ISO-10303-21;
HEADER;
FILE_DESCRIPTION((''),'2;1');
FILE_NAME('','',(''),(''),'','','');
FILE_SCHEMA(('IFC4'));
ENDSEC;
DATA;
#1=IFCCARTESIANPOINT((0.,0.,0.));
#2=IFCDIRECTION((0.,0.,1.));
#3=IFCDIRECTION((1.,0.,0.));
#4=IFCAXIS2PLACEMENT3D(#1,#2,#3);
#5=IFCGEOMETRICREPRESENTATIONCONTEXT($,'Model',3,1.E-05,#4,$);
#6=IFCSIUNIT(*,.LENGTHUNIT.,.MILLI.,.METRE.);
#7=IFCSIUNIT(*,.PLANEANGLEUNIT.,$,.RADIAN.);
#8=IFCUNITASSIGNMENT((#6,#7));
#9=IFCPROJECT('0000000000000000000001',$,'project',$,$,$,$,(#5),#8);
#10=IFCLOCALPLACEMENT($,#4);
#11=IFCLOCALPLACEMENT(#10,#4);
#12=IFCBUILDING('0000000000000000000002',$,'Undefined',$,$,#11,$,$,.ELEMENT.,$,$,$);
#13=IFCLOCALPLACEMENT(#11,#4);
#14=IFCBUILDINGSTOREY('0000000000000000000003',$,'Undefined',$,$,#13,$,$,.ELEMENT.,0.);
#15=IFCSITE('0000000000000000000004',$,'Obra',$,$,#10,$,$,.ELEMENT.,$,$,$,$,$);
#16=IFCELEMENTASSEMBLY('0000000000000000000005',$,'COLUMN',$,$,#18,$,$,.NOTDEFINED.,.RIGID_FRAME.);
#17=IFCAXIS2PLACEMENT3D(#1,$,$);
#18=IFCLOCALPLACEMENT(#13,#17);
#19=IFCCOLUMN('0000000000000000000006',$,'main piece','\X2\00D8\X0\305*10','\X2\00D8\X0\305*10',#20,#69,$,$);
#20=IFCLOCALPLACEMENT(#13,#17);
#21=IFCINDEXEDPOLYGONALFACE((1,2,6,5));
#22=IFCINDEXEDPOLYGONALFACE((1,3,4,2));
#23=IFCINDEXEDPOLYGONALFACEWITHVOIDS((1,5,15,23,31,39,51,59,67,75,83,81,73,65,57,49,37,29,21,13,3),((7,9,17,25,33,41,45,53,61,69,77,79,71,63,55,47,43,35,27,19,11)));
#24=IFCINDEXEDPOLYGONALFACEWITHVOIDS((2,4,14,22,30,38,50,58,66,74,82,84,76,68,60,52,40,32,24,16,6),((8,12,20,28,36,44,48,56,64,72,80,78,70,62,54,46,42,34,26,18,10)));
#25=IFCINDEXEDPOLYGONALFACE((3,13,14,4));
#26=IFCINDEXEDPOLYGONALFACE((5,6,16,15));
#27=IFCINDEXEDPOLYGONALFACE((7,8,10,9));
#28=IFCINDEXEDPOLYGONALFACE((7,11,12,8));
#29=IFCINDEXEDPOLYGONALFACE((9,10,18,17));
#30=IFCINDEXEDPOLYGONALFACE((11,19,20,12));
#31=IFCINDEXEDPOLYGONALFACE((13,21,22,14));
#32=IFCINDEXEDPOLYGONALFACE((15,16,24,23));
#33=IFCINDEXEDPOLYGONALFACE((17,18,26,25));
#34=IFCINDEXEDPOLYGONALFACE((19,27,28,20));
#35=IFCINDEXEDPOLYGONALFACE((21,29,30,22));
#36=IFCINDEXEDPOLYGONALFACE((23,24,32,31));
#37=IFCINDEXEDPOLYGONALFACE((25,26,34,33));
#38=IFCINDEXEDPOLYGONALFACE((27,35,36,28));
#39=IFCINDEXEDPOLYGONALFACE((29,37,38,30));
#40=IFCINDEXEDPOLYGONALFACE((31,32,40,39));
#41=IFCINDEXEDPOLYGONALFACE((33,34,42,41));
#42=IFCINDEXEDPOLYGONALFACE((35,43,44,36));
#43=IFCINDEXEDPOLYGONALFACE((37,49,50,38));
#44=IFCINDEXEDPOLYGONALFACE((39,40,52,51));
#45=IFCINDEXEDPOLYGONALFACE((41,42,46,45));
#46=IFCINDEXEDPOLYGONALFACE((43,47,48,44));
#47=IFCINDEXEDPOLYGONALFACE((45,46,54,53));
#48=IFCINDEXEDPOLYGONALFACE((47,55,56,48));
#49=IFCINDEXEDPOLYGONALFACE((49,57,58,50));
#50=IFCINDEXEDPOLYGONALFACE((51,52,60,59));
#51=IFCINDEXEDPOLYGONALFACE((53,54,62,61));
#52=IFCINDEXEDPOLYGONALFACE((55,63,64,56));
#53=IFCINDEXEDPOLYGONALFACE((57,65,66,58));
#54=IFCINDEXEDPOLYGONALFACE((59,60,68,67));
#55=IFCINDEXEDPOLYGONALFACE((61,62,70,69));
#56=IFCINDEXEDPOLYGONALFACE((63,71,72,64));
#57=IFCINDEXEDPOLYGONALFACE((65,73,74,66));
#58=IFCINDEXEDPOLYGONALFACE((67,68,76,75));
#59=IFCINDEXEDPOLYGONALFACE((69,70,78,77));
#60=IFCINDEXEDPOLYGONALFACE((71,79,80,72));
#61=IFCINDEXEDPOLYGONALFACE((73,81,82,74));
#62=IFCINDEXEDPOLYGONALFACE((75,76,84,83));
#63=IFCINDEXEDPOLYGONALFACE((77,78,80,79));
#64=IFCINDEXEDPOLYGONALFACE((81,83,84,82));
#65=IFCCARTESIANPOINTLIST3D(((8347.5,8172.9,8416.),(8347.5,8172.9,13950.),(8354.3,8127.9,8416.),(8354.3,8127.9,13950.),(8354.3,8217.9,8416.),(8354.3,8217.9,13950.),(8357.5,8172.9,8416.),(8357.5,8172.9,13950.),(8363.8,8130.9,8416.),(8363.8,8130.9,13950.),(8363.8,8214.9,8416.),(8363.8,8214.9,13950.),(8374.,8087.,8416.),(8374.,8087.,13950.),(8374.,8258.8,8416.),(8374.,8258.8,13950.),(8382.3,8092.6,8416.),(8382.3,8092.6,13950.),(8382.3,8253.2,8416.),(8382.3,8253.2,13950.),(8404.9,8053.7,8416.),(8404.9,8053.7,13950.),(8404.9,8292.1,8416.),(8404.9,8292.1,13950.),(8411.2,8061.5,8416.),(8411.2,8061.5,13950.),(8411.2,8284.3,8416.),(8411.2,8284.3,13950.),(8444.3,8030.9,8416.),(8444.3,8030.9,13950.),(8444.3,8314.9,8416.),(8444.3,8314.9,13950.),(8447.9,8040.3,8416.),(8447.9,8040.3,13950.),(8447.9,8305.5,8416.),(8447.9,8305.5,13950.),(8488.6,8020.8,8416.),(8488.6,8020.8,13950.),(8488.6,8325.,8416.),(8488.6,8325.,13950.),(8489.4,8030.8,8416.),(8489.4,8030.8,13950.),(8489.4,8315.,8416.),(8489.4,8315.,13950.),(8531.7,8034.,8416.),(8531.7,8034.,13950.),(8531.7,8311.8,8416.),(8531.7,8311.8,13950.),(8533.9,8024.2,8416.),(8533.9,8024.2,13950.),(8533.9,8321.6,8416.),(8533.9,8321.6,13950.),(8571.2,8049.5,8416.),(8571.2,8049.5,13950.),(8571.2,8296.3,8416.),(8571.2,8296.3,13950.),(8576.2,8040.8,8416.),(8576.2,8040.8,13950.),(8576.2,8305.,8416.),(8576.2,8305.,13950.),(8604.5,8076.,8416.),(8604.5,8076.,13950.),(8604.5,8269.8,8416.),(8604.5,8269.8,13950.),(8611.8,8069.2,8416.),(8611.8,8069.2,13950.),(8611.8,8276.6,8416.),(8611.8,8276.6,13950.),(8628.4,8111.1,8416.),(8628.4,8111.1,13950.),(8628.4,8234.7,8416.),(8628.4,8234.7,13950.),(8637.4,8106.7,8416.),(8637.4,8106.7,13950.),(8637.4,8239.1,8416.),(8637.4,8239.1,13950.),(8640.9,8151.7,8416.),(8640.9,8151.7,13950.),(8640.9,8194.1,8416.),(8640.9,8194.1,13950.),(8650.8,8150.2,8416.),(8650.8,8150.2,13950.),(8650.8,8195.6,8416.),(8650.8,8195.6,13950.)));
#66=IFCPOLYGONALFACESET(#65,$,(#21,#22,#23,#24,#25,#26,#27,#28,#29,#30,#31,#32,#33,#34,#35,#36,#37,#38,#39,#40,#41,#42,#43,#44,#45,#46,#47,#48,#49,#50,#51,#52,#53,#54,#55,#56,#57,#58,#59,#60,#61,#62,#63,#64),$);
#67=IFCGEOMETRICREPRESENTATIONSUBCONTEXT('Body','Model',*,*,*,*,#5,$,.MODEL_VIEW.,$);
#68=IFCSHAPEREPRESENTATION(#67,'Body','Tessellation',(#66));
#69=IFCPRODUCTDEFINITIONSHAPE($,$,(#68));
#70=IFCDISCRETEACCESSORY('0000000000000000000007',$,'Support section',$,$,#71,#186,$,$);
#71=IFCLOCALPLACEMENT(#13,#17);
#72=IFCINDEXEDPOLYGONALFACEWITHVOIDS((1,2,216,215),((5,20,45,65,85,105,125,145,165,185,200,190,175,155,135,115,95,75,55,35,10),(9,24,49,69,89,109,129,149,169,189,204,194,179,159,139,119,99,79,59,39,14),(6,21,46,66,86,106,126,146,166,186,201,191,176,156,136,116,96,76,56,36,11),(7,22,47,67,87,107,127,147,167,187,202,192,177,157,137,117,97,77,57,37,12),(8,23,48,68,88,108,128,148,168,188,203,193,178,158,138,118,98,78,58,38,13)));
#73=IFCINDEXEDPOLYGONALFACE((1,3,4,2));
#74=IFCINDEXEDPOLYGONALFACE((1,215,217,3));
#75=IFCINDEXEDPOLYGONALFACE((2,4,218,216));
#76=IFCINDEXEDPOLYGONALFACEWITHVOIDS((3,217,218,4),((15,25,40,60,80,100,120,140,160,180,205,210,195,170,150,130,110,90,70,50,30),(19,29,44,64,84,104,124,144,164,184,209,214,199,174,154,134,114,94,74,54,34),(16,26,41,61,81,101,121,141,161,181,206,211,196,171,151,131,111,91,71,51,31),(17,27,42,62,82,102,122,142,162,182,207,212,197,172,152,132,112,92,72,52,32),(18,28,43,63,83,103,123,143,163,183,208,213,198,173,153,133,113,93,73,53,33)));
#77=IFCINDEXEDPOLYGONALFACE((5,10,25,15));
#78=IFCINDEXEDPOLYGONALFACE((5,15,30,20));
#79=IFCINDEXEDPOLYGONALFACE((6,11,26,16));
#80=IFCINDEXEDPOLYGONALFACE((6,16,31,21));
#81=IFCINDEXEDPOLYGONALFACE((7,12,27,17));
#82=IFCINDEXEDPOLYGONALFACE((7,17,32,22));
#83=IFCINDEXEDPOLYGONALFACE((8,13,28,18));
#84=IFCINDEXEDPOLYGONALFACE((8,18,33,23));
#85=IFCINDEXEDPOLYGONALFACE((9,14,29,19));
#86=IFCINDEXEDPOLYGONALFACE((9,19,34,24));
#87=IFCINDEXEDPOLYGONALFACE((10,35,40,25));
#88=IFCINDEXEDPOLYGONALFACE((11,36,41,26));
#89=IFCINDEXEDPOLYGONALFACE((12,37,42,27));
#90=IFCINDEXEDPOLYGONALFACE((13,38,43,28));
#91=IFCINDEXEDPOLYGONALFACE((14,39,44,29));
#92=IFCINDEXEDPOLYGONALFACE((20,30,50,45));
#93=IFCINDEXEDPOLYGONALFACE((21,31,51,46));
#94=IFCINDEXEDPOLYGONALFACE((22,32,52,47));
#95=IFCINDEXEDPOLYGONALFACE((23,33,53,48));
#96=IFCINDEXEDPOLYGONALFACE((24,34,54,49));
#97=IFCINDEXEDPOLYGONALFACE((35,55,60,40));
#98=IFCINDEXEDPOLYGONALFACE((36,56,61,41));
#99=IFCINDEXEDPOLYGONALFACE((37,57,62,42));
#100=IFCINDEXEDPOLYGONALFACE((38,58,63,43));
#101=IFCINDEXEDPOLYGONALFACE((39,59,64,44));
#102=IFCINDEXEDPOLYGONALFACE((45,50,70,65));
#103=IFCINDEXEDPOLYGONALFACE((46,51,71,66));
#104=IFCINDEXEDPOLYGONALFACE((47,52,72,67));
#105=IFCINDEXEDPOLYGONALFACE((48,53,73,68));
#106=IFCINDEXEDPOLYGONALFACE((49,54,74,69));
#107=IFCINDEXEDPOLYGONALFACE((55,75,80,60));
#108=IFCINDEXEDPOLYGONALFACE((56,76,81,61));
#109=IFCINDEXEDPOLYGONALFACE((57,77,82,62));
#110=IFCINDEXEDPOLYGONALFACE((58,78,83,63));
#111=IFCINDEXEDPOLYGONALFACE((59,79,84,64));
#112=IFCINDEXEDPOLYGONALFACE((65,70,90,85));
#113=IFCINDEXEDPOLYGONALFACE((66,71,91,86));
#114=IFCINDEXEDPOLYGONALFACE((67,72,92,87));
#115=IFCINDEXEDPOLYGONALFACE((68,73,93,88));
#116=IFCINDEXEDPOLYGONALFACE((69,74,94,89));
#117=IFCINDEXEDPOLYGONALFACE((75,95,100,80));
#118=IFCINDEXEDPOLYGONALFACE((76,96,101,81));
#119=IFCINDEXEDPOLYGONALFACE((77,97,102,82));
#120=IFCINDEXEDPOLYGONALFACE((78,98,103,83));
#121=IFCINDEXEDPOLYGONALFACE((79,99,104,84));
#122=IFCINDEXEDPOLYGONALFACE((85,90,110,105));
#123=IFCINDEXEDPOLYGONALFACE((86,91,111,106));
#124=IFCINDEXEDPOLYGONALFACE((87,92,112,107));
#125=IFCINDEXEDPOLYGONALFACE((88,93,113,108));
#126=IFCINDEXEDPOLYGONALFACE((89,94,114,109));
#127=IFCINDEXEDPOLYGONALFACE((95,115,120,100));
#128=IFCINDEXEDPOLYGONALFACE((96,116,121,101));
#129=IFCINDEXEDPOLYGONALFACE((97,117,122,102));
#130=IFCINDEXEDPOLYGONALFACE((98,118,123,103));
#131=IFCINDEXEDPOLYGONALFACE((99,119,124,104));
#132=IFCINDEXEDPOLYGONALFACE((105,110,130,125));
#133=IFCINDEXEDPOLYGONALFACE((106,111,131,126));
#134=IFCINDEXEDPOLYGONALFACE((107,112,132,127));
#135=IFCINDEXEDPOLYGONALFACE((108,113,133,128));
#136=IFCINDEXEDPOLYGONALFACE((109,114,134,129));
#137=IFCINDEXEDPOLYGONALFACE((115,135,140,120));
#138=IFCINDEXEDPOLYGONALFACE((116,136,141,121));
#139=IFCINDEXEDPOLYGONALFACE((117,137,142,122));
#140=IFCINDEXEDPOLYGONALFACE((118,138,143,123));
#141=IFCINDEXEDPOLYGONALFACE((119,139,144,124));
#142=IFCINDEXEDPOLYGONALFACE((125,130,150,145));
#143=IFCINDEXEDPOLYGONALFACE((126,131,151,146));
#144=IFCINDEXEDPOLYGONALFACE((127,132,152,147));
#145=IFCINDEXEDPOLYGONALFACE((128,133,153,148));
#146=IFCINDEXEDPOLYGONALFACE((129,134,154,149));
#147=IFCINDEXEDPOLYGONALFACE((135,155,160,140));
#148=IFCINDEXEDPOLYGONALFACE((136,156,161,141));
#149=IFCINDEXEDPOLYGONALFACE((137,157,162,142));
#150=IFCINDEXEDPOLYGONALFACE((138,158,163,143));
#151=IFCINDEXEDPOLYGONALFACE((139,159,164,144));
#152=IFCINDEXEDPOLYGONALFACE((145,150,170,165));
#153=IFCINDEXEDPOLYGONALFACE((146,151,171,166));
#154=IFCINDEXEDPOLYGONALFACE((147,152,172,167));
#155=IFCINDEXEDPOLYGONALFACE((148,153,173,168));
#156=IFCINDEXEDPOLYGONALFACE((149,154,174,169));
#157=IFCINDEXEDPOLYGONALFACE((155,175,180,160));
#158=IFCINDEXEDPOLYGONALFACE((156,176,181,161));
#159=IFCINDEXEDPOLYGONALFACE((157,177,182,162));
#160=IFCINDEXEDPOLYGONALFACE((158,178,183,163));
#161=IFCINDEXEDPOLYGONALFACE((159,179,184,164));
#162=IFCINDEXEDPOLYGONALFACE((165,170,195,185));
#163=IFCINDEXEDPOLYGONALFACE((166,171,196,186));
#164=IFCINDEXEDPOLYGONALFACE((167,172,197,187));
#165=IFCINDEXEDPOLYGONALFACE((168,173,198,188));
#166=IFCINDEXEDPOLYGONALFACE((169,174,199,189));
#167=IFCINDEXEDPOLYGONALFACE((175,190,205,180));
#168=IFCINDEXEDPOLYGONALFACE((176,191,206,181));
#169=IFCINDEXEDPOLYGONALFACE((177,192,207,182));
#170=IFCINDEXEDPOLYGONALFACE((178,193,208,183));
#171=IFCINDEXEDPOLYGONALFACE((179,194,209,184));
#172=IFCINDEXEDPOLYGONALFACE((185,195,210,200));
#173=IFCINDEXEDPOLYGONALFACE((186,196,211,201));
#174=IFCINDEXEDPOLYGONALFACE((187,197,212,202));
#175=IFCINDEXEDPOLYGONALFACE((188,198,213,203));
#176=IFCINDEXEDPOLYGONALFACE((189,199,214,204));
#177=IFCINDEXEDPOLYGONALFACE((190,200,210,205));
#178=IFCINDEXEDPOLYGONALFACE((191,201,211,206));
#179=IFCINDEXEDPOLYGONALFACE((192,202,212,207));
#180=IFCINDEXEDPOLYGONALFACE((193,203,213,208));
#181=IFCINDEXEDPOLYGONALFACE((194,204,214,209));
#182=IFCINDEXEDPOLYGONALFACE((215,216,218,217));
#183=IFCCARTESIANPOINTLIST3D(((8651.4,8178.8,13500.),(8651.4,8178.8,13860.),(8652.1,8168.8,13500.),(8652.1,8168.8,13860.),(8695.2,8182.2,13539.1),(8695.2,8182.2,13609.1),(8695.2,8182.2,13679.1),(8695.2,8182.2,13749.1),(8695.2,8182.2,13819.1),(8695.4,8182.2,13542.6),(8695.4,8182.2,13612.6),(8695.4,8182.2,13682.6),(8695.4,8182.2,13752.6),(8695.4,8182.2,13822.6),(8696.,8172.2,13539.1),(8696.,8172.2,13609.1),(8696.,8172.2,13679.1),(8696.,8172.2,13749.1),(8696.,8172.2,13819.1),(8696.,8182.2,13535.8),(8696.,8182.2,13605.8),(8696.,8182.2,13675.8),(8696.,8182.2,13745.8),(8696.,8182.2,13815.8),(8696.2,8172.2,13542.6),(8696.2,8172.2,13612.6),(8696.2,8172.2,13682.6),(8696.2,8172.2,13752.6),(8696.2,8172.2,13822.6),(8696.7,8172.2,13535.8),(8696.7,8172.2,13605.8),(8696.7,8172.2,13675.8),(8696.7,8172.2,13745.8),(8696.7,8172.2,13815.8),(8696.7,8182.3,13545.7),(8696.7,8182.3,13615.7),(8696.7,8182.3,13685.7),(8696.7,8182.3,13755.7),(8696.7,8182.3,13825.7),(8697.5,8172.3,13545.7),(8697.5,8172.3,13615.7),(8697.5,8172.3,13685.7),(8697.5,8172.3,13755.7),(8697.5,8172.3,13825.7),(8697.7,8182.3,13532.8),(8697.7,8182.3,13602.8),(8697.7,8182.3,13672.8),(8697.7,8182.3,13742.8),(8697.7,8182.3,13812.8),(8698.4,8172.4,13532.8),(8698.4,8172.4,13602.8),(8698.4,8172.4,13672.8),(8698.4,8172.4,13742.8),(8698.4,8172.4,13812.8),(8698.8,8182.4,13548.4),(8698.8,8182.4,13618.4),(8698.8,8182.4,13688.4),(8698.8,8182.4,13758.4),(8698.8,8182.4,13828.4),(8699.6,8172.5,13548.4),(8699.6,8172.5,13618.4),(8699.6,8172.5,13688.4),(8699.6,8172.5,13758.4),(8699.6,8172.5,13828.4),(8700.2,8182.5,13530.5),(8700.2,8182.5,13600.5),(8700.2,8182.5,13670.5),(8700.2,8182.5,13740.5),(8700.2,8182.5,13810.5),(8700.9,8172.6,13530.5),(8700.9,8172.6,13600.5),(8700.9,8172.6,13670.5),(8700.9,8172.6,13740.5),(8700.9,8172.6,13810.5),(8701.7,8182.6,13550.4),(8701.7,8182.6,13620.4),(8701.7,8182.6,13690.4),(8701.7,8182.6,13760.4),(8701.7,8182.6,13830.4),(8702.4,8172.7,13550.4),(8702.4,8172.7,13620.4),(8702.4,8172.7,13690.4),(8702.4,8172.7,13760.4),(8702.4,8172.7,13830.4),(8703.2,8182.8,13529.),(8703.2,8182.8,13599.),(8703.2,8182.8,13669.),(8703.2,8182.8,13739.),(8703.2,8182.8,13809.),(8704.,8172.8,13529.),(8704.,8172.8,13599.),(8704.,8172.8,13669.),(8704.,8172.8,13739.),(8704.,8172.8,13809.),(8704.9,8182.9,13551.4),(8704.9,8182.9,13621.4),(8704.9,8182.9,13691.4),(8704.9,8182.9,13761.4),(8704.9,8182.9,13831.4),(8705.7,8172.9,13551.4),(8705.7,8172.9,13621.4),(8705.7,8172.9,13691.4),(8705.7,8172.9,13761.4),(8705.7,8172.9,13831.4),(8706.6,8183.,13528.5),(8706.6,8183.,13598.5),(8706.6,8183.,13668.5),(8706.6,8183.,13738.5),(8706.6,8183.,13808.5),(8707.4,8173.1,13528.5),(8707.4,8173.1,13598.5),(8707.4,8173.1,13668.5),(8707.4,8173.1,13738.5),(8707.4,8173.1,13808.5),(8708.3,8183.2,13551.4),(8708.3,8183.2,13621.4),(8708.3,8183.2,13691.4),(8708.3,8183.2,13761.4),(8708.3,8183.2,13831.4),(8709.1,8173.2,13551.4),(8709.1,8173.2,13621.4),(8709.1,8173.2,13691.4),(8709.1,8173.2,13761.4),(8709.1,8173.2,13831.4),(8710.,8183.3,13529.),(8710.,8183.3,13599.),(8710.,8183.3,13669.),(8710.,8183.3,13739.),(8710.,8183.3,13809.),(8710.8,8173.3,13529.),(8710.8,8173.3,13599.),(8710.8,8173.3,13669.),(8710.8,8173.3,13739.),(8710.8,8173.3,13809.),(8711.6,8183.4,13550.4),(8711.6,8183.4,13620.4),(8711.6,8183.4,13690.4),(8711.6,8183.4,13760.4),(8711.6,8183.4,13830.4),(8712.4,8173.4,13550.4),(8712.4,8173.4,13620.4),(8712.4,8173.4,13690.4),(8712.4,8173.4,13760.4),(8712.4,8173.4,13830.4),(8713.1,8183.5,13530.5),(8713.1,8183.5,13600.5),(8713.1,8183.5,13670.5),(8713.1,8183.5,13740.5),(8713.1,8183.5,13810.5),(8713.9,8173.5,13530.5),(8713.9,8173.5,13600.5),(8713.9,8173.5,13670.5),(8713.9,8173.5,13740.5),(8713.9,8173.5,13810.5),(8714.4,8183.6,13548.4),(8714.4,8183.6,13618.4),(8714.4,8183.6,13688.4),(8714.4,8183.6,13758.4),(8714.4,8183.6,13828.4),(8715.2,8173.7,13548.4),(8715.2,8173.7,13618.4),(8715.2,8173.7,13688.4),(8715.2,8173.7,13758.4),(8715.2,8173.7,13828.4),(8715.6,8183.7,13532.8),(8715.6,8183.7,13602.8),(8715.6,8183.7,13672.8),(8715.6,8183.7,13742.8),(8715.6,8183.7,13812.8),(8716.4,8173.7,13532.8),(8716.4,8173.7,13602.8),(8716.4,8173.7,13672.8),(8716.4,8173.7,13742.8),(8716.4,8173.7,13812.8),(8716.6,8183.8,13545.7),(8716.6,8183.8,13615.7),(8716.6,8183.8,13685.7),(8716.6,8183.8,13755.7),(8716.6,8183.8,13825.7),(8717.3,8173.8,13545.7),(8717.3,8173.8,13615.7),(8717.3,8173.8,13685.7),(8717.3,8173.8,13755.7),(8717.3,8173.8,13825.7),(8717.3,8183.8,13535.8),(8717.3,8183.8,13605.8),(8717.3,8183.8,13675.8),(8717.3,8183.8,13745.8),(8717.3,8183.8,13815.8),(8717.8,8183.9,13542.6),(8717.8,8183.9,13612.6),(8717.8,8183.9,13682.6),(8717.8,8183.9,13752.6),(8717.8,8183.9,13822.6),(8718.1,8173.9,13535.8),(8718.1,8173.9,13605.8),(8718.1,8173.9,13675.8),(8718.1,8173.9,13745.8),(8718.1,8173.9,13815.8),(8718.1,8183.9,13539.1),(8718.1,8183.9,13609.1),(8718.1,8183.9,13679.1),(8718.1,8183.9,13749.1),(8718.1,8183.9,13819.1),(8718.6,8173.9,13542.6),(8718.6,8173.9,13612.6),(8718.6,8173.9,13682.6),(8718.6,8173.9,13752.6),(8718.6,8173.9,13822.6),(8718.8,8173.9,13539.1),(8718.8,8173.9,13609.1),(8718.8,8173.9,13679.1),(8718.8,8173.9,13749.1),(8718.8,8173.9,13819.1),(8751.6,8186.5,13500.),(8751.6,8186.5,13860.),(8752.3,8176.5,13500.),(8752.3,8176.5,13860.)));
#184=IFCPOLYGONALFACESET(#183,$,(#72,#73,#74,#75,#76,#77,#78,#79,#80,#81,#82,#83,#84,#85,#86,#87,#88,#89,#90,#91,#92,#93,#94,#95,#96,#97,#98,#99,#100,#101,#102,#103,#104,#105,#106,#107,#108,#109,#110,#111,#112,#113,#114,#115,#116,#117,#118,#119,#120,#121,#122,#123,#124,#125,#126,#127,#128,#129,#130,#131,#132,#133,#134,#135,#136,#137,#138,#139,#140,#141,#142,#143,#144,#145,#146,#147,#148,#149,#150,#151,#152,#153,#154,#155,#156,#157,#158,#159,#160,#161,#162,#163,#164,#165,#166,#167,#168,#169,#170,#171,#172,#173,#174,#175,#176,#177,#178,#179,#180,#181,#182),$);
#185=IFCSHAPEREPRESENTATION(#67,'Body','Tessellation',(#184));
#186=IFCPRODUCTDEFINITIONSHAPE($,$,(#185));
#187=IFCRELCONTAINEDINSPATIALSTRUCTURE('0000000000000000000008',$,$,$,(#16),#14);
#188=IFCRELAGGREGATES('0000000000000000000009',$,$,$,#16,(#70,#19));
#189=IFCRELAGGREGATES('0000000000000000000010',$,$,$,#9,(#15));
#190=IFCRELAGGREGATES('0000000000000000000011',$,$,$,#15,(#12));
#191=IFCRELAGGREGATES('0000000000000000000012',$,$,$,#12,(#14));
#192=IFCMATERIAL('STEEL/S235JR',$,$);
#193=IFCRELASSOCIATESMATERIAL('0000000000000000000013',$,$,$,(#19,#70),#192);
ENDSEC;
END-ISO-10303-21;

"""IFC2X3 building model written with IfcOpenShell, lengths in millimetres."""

from ifc_helpers import new_model, si_unit, frame, origin_with_axes, origin_2d_with_axis, place, context, subcontext, project, spatial, rectangle, circle, hollow_circle, extrude, clip, halfspace, source, transform, mapped, material, element, aggregate, save


model = new_model("IFC2X3")

# Units and contexts
model_context = context("Model", 3, precision=1e-05, world=origin_with_axes())
body_context = subcontext(model_context, "Body", "Model", "MODEL_VIEW")
ifc_project = project(units=[si_unit("LENGTHUNIT", "METRE", prefix="MILLI"), si_unit("PLANEANGLEUNIT", "RADIAN")], contexts=[model_context])

# Site, building, storey
site_placement = place(None, origin_with_axes())
site = spatial("IfcSite", under=ifc_project, at=site_placement, Name="Obra", CompositionType="ELEMENT")
building_placement = place(site_placement, origin_with_axes())
building = spatial("IfcBuilding", under=site, at=building_placement, Name="Undefined", CompositionType="ELEMENT")
storey_placement = place(building_placement, origin_with_axes())
storey = spatial("IfcBuildingStorey", under=building, at=storey_placement, Name="Undefined", CompositionType="ELEMENT", Elevation=0.0)

# Element assembly, column
assembly_1_placement = place(storey_placement, origin_with_axes())
assembly_1 = element("IfcElementAssembly", 1, at=assembly_1_placement, inside=storey, Name="COLUMN", AssemblyPlace="NOTDEFINED", PredefinedType="RIGID_FRAME")
ifc_material_1 = material(Name="STEEL/S235JR")
column_placement = place(assembly_1_placement, frame((8500.0, 8172.9, 8400.0), z_axis=(0.0, 0.0, 1.0), x_axis=(0.0, 1.0, 0.0)))
column = element("IfcColumn", 2, at=column_placement, material=ifc_material_1, Name="main piece", Description="Ø305*10", ObjectType="Ø305*10", context=body_context, shape_type="Clipping", body=[
    clip(extrude(hollow_circle(Radius=152.5, WallThickness=10.0, at=origin_2d_with_axis()), frame((0.0, 0.0, 5550.0), z_axis=(0.0, 0.0, -1.0), x_axis=(0.0, 1.0, 0.0)), (0.0, 0.0, 1.0), 5534.0), halfspace(frame((-152.5, 0.0, 16.0), z_axis=(0.0, 0.0, 1.0), x_axis=(0.0, 1.0, 0.0)), True)),
])

# Discrete accessory, opening
discrete_accessory_1_placement = place(assembly_1_placement, frame((8701.8, 8177.6, 13500.0), z_axis=(0.0, 0.0, 1.0), x_axis=(-0.997092, -0.076204, 0.0)))
discrete_accessory_1 = element("IfcDiscreteAccessory", 3, at=discrete_accessory_1_placement, material=ifc_material_1, Name="Support section", context=body_context, shape_type="SweptSolid", body=[
    extrude(rectangle(XDim=10.0, YDim=100.5, at=origin_2d_with_axis()), frame((0.0, 0.0, 360.0), z_axis=(0.0, 0.0, -1.0), x_axis=(0.0, 1.0, 0.0)), (0.0, 0.0, 1.0), 360.0),
])
shared_shape_1 = source(origin_with_axes(), body_context, "Body", "SweptSolid", [
    extrude(circle(Radius=11.5, at=origin_2d_with_axis()), frame((0.0, -15.8, 0.0), z_axis=(0.0, 1.0, 0.0), x_axis=(1.0, 0.0, 0.0)), (0.0, 0.0, 1.0), 10.2),
])
opening_1_placement = place(assembly_1_placement, frame((8661.3, 8185.3, 13900.0), z_axis=(0.997092, 0.076204, 0.0), x_axis=(0.0, 0.0, -1.0)))
element("IfcOpeningElement", 4, at=opening_1_placement, cuts=discrete_accessory_1, ObjectType="Opening", context=body_context, shape_type="MappedRepresentation", body=[
    mapped(shared_shape_1, transform((80.0, 0.0, 45.0))),
    mapped(shared_shape_1, transform((150.0, 0.0, 45.0))),
    mapped(shared_shape_1, transform((220.0, 0.0, 45.0))),
    mapped(shared_shape_1, transform((290.0, 0.0, 45.0))),
    mapped(shared_shape_1, transform((360.0, 0.0, 45.0))),
])
aggregate(assembly_1, [discrete_accessory_1, column])

save(model, "model.ifc")
